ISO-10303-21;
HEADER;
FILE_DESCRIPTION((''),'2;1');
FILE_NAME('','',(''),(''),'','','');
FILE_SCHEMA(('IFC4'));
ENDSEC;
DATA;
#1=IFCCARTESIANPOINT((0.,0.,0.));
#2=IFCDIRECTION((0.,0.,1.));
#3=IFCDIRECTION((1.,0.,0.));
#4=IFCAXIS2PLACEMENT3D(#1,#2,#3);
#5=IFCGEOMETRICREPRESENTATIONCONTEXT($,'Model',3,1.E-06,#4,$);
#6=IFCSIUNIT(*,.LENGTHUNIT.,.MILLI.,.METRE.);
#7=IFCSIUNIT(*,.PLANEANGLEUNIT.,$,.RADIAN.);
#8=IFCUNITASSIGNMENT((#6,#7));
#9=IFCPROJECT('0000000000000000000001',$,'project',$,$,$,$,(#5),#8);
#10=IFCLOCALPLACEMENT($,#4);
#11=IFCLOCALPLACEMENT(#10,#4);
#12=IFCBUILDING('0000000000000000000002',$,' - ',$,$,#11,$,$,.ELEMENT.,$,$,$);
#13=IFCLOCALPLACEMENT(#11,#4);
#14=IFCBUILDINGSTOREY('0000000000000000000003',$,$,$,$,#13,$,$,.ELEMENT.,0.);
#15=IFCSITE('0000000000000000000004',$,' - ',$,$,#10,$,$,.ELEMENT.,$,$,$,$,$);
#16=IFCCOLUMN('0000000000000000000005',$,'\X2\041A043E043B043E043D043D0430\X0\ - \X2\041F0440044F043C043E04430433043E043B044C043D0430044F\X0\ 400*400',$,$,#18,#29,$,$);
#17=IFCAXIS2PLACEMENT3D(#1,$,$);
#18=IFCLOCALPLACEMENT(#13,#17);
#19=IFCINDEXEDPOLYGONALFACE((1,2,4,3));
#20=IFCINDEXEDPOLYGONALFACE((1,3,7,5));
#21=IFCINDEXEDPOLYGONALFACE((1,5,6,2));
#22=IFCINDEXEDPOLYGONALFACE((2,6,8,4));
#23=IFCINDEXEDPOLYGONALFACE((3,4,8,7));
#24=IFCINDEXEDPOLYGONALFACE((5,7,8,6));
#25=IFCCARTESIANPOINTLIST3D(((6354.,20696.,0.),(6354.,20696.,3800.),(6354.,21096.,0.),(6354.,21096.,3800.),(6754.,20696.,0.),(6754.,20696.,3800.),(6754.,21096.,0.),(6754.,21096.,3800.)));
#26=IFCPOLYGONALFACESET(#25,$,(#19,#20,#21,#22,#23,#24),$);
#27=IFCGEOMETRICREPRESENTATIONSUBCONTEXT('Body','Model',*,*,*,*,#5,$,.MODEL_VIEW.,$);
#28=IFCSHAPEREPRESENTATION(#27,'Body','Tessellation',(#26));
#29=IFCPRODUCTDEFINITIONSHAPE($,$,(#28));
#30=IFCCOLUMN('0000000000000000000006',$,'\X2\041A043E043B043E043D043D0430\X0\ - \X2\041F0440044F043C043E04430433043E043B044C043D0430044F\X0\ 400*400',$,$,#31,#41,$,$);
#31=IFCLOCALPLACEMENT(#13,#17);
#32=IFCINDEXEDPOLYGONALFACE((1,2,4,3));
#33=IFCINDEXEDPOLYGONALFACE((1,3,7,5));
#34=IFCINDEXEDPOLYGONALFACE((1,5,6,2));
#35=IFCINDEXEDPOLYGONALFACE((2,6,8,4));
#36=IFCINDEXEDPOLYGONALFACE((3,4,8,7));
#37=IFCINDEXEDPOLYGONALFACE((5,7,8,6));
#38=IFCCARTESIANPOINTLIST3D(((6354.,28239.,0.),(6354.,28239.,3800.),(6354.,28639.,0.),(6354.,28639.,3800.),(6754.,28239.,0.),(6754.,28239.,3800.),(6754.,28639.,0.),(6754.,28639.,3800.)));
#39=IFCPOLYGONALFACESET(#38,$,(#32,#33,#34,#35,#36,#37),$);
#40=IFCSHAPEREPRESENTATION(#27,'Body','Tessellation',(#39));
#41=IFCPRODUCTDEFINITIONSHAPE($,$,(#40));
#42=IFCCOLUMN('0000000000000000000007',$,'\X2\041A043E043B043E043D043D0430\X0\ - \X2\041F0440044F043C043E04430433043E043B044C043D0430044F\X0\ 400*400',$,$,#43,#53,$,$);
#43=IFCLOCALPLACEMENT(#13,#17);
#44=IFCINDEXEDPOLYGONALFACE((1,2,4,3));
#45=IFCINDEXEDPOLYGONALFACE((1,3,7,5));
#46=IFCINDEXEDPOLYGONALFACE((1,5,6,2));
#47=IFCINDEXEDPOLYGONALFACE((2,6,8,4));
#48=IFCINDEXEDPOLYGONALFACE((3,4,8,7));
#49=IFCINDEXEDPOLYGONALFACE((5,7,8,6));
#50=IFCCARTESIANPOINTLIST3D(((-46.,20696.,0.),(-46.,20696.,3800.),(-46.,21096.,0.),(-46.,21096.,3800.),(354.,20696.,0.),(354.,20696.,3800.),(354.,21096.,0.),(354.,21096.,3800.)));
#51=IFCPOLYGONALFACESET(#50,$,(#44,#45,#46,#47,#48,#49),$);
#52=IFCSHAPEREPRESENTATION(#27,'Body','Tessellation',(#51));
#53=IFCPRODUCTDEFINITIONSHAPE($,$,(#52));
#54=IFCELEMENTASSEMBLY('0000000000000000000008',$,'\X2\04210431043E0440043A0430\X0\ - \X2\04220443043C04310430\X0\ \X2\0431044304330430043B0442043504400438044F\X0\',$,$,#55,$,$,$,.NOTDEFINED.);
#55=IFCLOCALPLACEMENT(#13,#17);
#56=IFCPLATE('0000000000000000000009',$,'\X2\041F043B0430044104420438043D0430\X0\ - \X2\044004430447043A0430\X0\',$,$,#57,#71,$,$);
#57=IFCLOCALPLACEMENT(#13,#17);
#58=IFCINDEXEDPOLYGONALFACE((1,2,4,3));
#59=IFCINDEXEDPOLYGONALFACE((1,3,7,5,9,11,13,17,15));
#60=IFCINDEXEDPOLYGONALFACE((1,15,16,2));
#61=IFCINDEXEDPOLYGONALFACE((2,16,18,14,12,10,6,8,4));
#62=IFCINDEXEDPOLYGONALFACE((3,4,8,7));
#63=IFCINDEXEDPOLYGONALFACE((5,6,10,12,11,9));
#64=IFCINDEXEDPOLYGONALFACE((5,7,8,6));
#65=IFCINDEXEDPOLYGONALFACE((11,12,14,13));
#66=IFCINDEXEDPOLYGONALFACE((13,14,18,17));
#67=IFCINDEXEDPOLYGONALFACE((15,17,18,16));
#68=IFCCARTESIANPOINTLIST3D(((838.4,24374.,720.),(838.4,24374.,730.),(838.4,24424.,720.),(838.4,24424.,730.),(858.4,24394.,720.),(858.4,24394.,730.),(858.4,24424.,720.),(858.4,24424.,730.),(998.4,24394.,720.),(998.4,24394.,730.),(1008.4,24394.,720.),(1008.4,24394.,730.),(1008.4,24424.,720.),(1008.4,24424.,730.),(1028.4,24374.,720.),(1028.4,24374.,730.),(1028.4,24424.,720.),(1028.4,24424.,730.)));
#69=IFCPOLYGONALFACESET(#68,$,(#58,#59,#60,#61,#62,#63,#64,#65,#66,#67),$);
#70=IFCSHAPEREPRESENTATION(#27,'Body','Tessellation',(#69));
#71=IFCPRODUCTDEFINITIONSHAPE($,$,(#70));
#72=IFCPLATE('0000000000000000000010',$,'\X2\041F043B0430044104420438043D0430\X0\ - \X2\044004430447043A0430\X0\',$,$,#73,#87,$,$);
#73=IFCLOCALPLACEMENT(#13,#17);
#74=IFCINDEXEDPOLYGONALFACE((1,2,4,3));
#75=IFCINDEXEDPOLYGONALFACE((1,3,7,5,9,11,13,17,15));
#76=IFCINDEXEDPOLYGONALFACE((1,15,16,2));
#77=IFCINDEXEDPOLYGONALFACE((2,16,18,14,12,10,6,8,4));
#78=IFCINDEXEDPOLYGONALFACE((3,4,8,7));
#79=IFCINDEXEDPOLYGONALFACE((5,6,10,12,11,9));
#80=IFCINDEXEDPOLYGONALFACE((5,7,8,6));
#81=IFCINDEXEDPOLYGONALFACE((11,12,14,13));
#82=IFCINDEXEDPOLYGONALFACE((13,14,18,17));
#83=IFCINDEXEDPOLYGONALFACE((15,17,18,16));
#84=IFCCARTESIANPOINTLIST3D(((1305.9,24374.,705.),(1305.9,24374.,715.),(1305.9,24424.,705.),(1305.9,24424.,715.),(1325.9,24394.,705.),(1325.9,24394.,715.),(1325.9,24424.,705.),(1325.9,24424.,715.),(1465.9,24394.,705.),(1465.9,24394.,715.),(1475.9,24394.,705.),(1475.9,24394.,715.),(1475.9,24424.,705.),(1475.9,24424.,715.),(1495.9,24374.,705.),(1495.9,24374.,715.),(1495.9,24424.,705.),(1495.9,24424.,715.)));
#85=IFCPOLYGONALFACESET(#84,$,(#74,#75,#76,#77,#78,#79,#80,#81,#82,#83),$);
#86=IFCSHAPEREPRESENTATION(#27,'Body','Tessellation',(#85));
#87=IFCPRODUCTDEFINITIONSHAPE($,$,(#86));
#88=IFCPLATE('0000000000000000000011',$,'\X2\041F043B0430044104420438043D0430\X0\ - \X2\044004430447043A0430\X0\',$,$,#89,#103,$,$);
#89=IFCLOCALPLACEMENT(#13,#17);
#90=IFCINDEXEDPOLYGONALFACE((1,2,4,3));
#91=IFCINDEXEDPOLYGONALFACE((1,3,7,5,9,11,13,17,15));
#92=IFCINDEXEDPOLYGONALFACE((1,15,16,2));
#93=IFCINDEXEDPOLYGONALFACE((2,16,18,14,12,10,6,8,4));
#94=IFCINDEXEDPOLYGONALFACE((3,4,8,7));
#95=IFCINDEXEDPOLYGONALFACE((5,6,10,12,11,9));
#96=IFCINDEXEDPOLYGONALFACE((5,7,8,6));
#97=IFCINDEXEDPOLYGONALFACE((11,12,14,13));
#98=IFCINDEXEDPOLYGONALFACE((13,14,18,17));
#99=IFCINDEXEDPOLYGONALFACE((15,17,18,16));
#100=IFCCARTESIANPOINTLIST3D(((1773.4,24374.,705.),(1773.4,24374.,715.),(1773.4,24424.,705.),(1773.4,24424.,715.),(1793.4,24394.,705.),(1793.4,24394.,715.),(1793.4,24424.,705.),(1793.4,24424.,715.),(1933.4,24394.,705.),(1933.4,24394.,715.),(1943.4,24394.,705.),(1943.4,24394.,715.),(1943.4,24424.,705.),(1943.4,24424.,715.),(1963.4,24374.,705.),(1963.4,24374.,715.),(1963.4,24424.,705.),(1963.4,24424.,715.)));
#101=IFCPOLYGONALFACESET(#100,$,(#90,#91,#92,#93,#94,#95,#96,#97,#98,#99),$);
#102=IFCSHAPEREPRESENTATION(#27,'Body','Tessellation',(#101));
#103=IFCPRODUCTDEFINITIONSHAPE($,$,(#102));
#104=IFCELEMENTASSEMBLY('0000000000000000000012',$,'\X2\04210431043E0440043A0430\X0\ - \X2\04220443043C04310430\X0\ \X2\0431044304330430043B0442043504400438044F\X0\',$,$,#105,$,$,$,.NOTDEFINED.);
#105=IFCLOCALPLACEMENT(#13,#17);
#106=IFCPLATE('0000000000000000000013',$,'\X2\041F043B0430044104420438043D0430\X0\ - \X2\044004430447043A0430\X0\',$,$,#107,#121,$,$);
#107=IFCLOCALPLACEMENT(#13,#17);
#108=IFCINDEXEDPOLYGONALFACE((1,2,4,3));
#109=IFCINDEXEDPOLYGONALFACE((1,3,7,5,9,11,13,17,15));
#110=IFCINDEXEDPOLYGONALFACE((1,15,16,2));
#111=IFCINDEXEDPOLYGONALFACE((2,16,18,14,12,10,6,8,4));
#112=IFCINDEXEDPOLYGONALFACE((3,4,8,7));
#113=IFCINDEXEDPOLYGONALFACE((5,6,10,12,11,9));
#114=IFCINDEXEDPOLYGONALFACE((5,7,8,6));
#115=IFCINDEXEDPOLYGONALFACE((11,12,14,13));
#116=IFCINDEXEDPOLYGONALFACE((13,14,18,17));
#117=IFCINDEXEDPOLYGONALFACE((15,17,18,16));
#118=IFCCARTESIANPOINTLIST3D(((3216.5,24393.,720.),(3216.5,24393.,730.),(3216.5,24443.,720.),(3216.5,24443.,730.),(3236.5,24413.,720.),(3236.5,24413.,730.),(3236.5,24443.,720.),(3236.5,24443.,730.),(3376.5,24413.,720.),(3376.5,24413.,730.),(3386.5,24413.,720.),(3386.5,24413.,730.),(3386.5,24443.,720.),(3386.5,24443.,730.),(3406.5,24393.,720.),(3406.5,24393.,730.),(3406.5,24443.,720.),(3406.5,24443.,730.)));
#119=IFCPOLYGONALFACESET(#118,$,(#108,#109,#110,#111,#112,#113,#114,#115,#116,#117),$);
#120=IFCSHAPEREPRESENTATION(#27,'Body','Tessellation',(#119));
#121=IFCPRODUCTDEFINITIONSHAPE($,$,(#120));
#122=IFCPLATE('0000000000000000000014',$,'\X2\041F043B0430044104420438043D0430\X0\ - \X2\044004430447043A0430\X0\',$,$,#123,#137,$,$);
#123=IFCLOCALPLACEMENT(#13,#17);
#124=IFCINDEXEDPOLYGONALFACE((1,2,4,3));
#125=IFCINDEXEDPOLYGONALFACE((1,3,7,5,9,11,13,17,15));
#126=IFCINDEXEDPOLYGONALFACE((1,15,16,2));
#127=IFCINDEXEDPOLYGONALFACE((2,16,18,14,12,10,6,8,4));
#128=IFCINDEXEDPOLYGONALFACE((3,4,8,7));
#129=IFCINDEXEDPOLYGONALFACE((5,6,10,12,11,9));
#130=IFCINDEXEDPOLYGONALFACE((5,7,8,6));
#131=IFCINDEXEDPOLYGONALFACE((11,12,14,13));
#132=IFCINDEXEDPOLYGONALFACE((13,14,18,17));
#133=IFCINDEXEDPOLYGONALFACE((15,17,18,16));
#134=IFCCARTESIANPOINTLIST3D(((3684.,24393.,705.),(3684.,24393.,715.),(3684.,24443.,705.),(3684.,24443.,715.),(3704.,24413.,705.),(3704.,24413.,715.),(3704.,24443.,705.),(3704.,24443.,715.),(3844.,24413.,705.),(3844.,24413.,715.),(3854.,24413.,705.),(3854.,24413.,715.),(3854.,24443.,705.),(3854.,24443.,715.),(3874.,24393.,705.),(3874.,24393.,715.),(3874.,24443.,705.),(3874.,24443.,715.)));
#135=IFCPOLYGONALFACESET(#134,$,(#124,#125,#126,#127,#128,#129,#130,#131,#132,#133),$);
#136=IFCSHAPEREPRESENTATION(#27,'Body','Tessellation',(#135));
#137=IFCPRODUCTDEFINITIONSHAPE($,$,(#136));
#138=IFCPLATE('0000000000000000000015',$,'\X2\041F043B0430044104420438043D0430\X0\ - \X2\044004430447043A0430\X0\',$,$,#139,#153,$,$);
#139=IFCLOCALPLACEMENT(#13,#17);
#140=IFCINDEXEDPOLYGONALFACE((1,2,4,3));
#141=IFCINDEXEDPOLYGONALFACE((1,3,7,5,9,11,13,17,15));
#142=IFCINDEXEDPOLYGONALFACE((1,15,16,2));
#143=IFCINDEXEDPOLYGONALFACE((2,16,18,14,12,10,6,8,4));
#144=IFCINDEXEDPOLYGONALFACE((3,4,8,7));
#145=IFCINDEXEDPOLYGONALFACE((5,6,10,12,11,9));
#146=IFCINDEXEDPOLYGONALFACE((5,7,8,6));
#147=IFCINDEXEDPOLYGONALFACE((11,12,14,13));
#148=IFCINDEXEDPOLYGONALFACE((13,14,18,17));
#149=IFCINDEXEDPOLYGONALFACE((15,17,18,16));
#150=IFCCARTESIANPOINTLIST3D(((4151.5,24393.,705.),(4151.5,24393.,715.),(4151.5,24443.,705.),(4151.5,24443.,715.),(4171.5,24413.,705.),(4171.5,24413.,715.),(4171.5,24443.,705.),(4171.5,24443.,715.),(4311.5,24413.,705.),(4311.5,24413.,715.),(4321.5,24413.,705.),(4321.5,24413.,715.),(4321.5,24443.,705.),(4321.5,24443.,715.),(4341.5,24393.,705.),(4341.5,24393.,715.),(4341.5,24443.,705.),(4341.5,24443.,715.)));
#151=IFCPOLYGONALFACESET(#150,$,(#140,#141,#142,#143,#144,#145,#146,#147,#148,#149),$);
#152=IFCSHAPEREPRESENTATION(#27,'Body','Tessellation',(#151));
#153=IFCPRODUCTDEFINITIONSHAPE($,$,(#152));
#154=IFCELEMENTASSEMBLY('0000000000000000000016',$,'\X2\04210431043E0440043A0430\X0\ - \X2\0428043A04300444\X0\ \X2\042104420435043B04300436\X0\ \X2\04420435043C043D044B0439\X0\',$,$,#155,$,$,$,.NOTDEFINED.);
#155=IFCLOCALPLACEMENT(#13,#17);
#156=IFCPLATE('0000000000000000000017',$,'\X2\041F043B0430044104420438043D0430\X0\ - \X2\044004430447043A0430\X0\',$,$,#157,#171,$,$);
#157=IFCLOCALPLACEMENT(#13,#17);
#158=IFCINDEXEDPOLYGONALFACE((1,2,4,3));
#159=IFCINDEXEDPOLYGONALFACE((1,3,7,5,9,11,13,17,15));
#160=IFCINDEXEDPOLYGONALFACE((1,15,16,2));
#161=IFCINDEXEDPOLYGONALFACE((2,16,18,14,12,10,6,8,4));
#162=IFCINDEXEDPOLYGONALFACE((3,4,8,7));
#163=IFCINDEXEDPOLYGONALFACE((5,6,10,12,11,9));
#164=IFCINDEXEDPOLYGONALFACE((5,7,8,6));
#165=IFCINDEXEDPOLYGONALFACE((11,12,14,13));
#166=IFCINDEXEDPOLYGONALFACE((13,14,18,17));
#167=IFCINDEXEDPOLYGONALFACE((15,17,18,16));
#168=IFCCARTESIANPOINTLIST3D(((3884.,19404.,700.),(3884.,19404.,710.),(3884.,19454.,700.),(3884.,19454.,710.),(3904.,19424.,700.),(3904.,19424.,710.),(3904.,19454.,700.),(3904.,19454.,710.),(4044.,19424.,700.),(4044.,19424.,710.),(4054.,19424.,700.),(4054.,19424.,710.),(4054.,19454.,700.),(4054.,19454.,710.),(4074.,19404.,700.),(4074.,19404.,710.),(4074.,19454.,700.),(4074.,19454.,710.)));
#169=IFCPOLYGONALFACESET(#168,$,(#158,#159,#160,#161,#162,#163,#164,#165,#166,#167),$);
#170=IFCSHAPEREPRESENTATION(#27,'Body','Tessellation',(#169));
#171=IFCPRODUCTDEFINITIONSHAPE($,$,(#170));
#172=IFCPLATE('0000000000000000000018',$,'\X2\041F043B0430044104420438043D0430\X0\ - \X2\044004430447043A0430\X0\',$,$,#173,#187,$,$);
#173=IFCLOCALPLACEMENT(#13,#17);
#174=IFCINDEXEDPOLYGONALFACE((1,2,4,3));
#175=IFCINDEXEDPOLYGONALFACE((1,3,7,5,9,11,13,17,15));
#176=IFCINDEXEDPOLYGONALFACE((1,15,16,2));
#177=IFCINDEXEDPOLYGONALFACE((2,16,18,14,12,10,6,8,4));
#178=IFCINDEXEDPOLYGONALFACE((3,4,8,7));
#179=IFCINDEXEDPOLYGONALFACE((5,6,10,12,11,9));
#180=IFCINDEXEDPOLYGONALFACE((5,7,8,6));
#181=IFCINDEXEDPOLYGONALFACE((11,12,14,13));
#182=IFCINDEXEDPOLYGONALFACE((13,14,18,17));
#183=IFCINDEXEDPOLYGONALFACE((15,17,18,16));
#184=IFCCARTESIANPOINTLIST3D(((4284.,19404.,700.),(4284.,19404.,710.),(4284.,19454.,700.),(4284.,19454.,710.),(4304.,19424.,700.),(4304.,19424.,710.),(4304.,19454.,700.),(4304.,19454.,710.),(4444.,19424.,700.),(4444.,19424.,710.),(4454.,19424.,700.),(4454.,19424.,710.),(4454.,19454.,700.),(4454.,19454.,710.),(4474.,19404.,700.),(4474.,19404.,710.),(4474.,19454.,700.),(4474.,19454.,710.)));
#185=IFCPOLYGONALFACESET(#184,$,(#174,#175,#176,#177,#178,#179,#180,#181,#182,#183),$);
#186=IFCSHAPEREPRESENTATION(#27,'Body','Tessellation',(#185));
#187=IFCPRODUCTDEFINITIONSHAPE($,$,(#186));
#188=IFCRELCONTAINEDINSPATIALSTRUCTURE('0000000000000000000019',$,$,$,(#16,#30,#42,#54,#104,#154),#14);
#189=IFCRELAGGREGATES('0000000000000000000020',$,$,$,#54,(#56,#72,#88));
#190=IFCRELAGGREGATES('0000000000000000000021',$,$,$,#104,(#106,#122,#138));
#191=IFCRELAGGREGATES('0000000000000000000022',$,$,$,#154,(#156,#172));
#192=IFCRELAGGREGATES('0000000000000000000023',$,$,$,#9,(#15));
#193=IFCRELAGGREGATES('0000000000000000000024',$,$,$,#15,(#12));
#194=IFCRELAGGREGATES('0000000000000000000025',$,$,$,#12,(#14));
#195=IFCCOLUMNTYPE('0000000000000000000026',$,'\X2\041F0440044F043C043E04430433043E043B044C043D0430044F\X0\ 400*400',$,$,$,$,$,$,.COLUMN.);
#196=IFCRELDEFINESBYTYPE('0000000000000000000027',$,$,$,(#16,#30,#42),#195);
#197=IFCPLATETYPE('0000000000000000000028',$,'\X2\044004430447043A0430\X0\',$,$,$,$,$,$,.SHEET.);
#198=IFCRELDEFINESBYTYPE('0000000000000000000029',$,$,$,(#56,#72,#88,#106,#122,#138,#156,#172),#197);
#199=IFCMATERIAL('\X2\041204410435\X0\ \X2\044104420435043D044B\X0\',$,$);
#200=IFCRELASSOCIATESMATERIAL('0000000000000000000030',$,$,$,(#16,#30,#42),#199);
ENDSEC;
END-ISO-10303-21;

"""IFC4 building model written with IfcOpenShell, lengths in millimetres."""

from ifc_helpers import new_model, si_unit, frame, origin_with_axes, place, context, subcontext, project, spatial, line, indexed_curve, outline, extrude, source, transform, mapped, material, type_object, element, aggregate, save


model = new_model("IFC4")

# Units and contexts
model_context = context("Model", 3, precision=1e-06, world=origin_with_axes())
body_context = subcontext(model_context, "Body", "Model", "MODEL_VIEW")
ifc_project = project(units=[si_unit("LENGTHUNIT", "METRE", prefix="MILLI"), si_unit("PLANEANGLEUNIT", "RADIAN")], contexts=[model_context])

# Site, building, storey
site_placement = place(None, origin_with_axes())
site = spatial("IfcSite", under=ifc_project, at=site_placement, Name=" - ", CompositionType="ELEMENT")
building_placement = place(site_placement, origin_with_axes())
building = spatial("IfcBuilding", under=site, at=building_placement, Name=" - ", CompositionType="ELEMENT")
storey_placement = place(building_placement, origin_with_axes())
storey = spatial("IfcBuildingStorey", under=building, at=storey_placement, CompositionType="ELEMENT", Elevation=0.0)

# Columns
ifc_material = material(Name="Все стены")
column_type = type_object("IfcColumnType", Name="Прямоугольная 400*400", PredefinedType="COLUMN")
shared_shape_1 = source(origin_with_axes(), body_context, "Body", "SweptSolid", [
    extrude(outline(indexed_curve([(-200.0, -200.0), (200.0, -200.0), (200.0, 200.0), (-200.0, 200.0)], segments=[line(1, 2), line(2, 3), line(3, 4), line(4, 1)])), origin_with_axes(), (0.0, 0.0, 1.0), 3800.0),
])
for number, where, z_axis, x_axis, name in (
    (1, (6554.0, 20896.0, 0.0), (0.0, 0.0, 1.0), (1.0, 0.0, 0.0), "Колонна - Прямоугольная 400*400"),
    (2, (6554.0, 28439.0, 0.0), (0.0, 0.0, 1.0), (1.0, 0.0, 0.0), "Колонна - Прямоугольная 400*400"),
    (3, (154.0, 20896.0, 0.0), (0.0, 0.0, 1.0), (1.0, 0.0, 0.0), "Колонна - Прямоугольная 400*400"),
):
    element("IfcColumn", number, at=place(storey_placement, frame(where, z_axis=z_axis, x_axis=x_axis)), inside=storey, type_object=column_type, material=ifc_material, Name=name, context=body_context, shape_type="MappedRepresentation", body=[
        mapped(shared_shape_1, transform((0.0, 0.0, 0.0), x_axis=(1.0, 0.0, 0.0), y_axis=(0.0, 1.0, 0.0), z_axis=(0.0, 0.0, 1.0), scale=1.0)),
    ])

# Element assemblies, plates
assembly_1_placement = place(storey_placement, frame((1400.9, 24639.0, 0.0), z_axis=(0.0, 0.0, 1.0), x_axis=(1.0, 0.0, 0.0)))
assembly_1 = element("IfcElementAssembly", 4, at=assembly_1_placement, inside=storey, Name="Сборка - Тумба бугалтерия", PredefinedType="NOTDEFINED")
plate_type_1 = type_object("IfcPlateType", Name="ручка", PredefinedType="SHEET")
shared_shape_2 = source(origin_with_axes(), body_context, "Body", "SweptSolid", [
    extrude(outline(indexed_curve([(-95.0, -25.0), (-75.0, -25.0), (-75.0, 5.0), (-65.0, 5.0), (75.0, 5.0), (75.0, -25.0), (95.0, -25.0), (95.0, 25.0), (-95.0, 25.0)], segments=[line(1, 2), line(2, 3), line(3, 4), line(4, 5), line(5, 6), line(6, 7), line(7, 8), line(8, 9), line(9, 1)])), origin_with_axes(), (0.0, 0.0, 1.0), 10.0),
])
plate_1_placement = place(assembly_1_placement, frame((-467.5, -240.0, 720.0), z_axis=(0.0, 0.0, 1.0), x_axis=(-1.0, 0.0, 0.0)))
plate_1 = element("IfcPlate", 5, at=plate_1_placement, type_object=plate_type_1, Name="Пластина - ручка", context=body_context, shape_type="MappedRepresentation", body=[
    mapped(shared_shape_2, transform((0.0, 0.0, 0.0), x_axis=(1.0, 0.0, 0.0), y_axis=(0.0, 1.0, 0.0), z_axis=(0.0, 0.0, 1.0), scale=1.0)),
])
plate_2_placement = place(assembly_1_placement, frame((0.0, -240.0, 705.0), z_axis=(0.0, 0.0, 1.0), x_axis=(-1.0, 0.0, 0.0)))
plate_2 = element("IfcPlate", 6, at=plate_2_placement, type_object=plate_type_1, Name="Пластина - ручка", context=body_context, shape_type="MappedRepresentation", body=[
    mapped(shared_shape_2, transform((0.0, 0.0, 0.0), x_axis=(1.0, 0.0, 0.0), y_axis=(0.0, 1.0, 0.0), z_axis=(0.0, 0.0, 1.0), scale=1.0)),
])
plate_3_placement = place(assembly_1_placement, frame((467.5, -240.0, 705.0), z_axis=(0.0, 0.0, 1.0), x_axis=(-1.0, 0.0, 0.0)))
plate_3 = element("IfcPlate", 7, at=plate_3_placement, type_object=plate_type_1, Name="Пластина - ручка", context=body_context, shape_type="MappedRepresentation", body=[
    mapped(shared_shape_2, transform((0.0, 0.0, 0.0), x_axis=(1.0, 0.0, 0.0), y_axis=(0.0, 1.0, 0.0), z_axis=(0.0, 0.0, 1.0), scale=1.0)),
])
aggregate(assembly_1, [plate_1, plate_2, plate_3])
assembly_2_placement = place(storey_placement, frame((3779.0, 24658.0, 0.0), z_axis=(0.0, 0.0, 1.0), x_axis=(1.0, 0.0, 0.0)))
assembly_2 = element("IfcElementAssembly", 8, at=assembly_2_placement, inside=storey, Name="Сборка - Тумба бугалтерия", PredefinedType="NOTDEFINED")
plate_4_placement = place(assembly_2_placement, frame((-467.5, -240.0, 720.0), z_axis=(0.0, 0.0, 1.0), x_axis=(-1.0, 0.0, 0.0)))
plate_4 = element("IfcPlate", 9, at=plate_4_placement, type_object=plate_type_1, Name="Пластина - ручка", context=body_context, shape_type="MappedRepresentation", body=[
    mapped(shared_shape_2, transform((0.0, 0.0, 0.0), x_axis=(1.0, 0.0, 0.0), y_axis=(0.0, 1.0, 0.0), z_axis=(0.0, 0.0, 1.0), scale=1.0)),
])
plate_5_placement = place(assembly_2_placement, frame((0.0, -240.0, 705.0), z_axis=(0.0, 0.0, 1.0), x_axis=(-1.0, 0.0, 0.0)))
plate_5 = element("IfcPlate", 10, at=plate_5_placement, type_object=plate_type_1, Name="Пластина - ручка", context=body_context, shape_type="MappedRepresentation", body=[
    mapped(shared_shape_2, transform((0.0, 0.0, 0.0), x_axis=(1.0, 0.0, 0.0), y_axis=(0.0, 1.0, 0.0), z_axis=(0.0, 0.0, 1.0), scale=1.0)),
])
plate_6_placement = place(assembly_2_placement, frame((467.5, -240.0, 705.0), z_axis=(0.0, 0.0, 1.0), x_axis=(-1.0, 0.0, 0.0)))
plate_6 = element("IfcPlate", 11, at=plate_6_placement, type_object=plate_type_1, Name="Пластина - ручка", context=body_context, shape_type="MappedRepresentation", body=[
    mapped(shared_shape_2, transform((0.0, 0.0, 0.0), x_axis=(1.0, 0.0, 0.0), y_axis=(0.0, 1.0, 0.0), z_axis=(0.0, 0.0, 1.0), scale=1.0)),
])
aggregate(assembly_2, [plate_4, plate_5, plate_6])
assembly_3_placement = place(storey_placement, frame((3779.0, 19469.0, 0.0), z_axis=(0.0, 0.0, 1.0), x_axis=(1.0, 0.0, 0.0)))
assembly_3 = element("IfcElementAssembly", 12, at=assembly_3_placement, inside=storey, Name="Сборка - Шкаф Стелаж темный", PredefinedType="NOTDEFINED")
plate_7_placement = place(assembly_3_placement, frame((200.0, -40.0, 700.0), z_axis=(0.0, 0.0, 1.0), x_axis=(-1.0, 0.0, 0.0)))
plate_7 = element("IfcPlate", 13, at=plate_7_placement, type_object=plate_type_1, Name="Пластина - ручка", context=body_context, shape_type="MappedRepresentation", body=[
    mapped(shared_shape_2, transform((0.0, 0.0, 0.0), x_axis=(1.0, 0.0, 0.0), y_axis=(0.0, 1.0, 0.0), z_axis=(0.0, 0.0, 1.0), scale=1.0)),
])
plate_8_placement = place(assembly_3_placement, frame((600.0, -40.0, 700.0), z_axis=(0.0, 0.0, 1.0), x_axis=(-1.0, 0.0, 0.0)))
plate_8 = element("IfcPlate", 14, at=plate_8_placement, type_object=plate_type_1, Name="Пластина - ручка", context=body_context, shape_type="MappedRepresentation", body=[
    mapped(shared_shape_2, transform((0.0, 0.0, 0.0), x_axis=(1.0, 0.0, 0.0), y_axis=(0.0, 1.0, 0.0), z_axis=(0.0, 0.0, 1.0), scale=1.0)),
])
aggregate(assembly_3, [plate_7, plate_8])

save(model, "model.ifc")
